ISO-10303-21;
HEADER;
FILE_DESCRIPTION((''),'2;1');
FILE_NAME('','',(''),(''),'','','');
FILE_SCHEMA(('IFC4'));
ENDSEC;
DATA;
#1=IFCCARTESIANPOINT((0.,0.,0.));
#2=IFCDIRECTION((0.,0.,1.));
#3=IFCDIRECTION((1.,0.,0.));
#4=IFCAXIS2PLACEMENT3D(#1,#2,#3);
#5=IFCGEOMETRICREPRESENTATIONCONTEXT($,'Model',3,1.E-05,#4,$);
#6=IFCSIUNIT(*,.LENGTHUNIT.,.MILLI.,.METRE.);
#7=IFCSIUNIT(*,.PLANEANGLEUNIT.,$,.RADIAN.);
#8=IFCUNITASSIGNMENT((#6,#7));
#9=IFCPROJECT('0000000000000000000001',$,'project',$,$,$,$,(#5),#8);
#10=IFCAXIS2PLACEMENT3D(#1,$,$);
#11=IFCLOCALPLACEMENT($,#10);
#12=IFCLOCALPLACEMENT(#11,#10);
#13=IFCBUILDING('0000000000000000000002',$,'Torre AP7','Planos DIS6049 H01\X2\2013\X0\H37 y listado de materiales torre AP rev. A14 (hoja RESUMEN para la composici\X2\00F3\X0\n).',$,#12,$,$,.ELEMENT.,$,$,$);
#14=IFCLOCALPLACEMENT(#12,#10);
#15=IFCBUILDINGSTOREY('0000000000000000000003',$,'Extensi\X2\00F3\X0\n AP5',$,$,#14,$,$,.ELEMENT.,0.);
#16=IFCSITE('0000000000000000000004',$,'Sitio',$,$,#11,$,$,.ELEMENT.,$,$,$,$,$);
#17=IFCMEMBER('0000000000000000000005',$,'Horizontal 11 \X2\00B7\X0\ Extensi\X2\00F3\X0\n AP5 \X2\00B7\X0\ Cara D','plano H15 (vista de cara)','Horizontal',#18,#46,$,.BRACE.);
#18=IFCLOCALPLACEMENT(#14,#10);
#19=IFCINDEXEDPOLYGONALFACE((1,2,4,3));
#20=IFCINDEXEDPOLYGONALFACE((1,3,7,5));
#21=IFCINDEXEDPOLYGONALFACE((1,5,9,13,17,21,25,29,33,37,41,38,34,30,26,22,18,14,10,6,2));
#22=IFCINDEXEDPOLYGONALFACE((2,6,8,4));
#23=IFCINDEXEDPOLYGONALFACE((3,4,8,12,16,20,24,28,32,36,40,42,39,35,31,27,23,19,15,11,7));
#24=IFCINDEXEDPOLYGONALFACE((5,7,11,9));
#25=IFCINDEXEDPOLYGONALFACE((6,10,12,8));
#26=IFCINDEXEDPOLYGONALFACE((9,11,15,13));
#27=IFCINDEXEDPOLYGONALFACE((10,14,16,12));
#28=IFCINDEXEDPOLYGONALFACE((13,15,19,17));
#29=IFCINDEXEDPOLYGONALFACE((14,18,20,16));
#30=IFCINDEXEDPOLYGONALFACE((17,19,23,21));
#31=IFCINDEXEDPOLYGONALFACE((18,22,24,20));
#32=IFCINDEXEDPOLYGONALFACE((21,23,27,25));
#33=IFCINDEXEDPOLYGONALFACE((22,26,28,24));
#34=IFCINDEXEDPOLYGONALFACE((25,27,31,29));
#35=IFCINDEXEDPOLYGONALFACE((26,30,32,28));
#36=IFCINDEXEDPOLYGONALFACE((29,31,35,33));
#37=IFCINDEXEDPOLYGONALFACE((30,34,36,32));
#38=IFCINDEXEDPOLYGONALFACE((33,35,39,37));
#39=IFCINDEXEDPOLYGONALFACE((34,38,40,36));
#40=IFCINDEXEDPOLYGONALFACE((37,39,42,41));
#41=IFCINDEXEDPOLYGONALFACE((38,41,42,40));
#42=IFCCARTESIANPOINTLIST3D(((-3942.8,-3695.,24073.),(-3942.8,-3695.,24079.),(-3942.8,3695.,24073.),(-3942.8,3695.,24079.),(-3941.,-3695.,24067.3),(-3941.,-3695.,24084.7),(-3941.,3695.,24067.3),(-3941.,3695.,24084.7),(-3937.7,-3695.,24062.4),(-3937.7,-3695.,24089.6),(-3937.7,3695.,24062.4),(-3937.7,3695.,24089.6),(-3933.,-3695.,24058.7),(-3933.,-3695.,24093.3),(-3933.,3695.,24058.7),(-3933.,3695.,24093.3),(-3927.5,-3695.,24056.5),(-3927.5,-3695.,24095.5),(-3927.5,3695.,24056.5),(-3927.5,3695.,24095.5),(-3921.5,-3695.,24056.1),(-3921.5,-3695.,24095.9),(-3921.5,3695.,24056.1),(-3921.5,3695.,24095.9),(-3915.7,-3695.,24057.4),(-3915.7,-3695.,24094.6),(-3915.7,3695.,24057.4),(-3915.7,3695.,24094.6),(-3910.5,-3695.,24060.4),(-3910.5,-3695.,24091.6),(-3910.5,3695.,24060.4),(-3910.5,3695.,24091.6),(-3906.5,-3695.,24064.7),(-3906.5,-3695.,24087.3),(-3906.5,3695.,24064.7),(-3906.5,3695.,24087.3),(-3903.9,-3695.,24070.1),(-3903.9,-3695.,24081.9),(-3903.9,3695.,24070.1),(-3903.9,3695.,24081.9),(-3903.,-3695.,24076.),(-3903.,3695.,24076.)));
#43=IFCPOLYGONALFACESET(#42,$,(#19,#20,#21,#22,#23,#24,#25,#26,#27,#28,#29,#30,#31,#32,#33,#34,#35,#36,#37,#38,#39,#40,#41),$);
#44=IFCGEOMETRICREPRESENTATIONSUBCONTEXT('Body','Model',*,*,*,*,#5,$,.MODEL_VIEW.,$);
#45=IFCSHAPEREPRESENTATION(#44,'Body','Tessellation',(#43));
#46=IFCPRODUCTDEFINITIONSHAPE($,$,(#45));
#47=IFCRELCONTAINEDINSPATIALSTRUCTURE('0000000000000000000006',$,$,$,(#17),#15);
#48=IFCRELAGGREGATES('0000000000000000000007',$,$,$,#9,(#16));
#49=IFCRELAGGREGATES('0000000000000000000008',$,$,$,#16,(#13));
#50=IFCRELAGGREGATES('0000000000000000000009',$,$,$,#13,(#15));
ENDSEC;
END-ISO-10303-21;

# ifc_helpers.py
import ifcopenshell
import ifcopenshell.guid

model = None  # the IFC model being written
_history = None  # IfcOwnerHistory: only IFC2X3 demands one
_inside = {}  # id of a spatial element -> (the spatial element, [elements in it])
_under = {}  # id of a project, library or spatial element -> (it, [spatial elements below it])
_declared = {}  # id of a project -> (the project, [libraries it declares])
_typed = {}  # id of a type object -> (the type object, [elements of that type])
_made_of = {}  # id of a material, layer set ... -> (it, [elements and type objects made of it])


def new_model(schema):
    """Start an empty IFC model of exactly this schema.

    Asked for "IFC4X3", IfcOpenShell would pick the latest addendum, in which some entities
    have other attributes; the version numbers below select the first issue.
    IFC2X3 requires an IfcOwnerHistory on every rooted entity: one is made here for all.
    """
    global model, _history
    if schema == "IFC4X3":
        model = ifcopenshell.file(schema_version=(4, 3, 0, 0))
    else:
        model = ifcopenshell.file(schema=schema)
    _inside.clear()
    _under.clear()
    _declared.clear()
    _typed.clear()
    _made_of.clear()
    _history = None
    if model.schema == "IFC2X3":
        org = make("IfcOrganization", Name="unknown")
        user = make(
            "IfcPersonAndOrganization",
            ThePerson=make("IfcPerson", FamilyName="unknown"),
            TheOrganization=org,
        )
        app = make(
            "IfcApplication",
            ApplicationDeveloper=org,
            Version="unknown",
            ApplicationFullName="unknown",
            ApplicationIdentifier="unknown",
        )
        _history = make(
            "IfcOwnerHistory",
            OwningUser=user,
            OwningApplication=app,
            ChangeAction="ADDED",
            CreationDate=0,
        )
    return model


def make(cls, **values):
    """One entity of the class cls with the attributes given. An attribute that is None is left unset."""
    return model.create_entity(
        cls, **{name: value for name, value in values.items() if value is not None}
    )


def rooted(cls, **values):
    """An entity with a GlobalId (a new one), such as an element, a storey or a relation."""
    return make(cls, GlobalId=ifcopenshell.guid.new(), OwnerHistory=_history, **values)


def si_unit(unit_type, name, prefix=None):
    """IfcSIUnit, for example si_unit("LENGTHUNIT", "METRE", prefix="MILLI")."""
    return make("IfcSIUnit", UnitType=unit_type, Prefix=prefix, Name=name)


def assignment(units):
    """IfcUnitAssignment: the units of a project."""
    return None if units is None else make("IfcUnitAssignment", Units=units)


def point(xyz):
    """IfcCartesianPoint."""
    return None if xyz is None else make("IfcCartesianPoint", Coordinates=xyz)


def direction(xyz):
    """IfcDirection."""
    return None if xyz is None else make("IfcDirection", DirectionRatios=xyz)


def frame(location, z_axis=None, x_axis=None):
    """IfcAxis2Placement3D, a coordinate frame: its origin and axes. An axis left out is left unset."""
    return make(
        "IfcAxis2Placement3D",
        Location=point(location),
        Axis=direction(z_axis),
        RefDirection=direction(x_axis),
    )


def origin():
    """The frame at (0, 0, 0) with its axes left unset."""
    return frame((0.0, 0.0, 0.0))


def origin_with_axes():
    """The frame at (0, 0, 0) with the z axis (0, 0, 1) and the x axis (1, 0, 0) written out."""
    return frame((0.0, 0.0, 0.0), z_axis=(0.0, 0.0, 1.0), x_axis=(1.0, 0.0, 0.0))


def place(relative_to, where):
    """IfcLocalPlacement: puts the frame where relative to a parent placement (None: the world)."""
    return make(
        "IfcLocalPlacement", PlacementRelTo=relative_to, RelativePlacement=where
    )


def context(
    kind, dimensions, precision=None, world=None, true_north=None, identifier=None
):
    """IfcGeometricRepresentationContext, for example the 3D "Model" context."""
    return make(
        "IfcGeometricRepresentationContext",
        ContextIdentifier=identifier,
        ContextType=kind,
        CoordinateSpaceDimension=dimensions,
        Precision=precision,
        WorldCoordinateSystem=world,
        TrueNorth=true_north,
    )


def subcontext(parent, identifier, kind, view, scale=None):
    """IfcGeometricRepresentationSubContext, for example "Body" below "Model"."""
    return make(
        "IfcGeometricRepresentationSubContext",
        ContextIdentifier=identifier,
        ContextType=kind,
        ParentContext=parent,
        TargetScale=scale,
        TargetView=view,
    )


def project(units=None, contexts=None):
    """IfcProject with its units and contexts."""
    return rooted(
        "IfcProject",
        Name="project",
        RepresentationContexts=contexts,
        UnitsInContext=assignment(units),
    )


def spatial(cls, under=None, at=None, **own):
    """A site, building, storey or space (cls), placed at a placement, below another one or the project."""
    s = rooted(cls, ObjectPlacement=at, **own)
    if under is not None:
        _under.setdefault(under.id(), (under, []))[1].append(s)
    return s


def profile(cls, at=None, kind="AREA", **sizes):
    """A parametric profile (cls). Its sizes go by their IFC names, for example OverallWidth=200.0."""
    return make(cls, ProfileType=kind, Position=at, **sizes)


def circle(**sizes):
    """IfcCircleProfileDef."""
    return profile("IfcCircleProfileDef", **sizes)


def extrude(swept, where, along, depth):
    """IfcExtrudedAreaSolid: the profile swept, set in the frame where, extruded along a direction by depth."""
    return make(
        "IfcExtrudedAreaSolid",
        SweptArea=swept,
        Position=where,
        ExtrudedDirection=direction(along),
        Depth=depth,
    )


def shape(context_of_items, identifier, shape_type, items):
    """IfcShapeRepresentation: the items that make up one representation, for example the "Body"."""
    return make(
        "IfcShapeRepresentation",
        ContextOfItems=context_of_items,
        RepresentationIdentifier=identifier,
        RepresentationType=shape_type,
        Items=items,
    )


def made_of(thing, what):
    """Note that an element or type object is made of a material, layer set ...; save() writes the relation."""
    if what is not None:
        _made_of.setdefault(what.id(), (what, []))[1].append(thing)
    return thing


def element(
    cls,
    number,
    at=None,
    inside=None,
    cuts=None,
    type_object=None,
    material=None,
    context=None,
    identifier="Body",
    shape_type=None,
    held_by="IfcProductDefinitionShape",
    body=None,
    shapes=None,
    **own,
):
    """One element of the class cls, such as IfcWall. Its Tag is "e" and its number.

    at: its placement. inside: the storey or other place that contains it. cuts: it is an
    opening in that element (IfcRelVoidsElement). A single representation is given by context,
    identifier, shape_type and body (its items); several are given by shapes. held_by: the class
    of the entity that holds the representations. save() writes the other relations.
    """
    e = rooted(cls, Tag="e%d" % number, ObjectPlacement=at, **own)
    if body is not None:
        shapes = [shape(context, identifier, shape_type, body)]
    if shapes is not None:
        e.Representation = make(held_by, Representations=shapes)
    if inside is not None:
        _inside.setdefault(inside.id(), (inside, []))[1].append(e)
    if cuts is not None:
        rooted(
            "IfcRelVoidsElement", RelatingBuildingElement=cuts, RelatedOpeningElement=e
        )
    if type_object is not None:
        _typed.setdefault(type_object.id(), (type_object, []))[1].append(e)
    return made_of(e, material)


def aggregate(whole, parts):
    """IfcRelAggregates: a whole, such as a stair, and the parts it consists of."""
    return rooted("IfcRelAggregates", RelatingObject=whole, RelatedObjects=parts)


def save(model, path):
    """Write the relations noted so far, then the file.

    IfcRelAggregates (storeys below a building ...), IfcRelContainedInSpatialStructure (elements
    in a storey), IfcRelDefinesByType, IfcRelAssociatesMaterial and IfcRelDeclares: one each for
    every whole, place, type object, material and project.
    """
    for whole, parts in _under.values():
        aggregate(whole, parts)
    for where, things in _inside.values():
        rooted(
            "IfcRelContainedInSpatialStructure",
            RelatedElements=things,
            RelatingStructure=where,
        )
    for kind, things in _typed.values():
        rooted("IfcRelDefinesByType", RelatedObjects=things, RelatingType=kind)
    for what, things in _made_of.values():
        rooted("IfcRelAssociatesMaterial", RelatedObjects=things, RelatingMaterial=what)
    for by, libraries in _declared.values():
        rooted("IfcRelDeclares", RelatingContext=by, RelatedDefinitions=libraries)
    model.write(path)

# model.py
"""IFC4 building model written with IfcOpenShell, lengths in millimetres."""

from ifc_helpers import new_model, si_unit, frame, origin, origin_with_axes, place, context, subcontext, project, spatial, circle, extrude, element, save


model = new_model("IFC4")

# Units and contexts
model_context = context("Model", 3, precision=1e-05, world=origin_with_axes())
body_context = subcontext(model_context, "Body", "Model", "MODEL_VIEW")
ifc_project = project(units=[si_unit("LENGTHUNIT", "METRE", prefix="MILLI"), si_unit("PLANEANGLEUNIT", "RADIAN")], contexts=[model_context])

# Site, building, storey
site_placement = place(None, origin())
site = spatial("IfcSite", under=ifc_project, at=site_placement, Name="Sitio", CompositionType="ELEMENT")
building_placement = place(site_placement, origin())
building = spatial("IfcBuilding", under=site, at=building_placement, Name="Torre AP7", Description="Planos DIS6049 H01–H37 y listado de materiales torre AP rev. A14 (hoja RESUMEN para la composición).", CompositionType="ELEMENT")
storey_placement = place(building_placement, origin())
storey = spatial("IfcBuildingStorey", under=building, at=storey_placement, Name="Extensión AP5", CompositionType="ELEMENT", Elevation=0.0)

# Member
for number, where, z_axis, x_axis, name in (
    (1, (-3923.0, -3695.0, 24076.0), (0.0, 1.0, 0.0), (1.0, 0.0, 0.0), "Horizontal 11 · Extensión AP5 · Cara D"),
):
    element("IfcMember", number, at=place(storey_placement, frame(where, z_axis=z_axis, x_axis=x_axis)), inside=storey, Name=name, Description="plano H15 (vista de cara)", ObjectType="Horizontal", PredefinedType="BRACE", context=body_context, shape_type="SweptSolid", body=[
        extrude(circle(Radius=20.0), None, (0.0, 0.0, 1.0), 7390.0),
    ])

save(model, "model.ifc")
